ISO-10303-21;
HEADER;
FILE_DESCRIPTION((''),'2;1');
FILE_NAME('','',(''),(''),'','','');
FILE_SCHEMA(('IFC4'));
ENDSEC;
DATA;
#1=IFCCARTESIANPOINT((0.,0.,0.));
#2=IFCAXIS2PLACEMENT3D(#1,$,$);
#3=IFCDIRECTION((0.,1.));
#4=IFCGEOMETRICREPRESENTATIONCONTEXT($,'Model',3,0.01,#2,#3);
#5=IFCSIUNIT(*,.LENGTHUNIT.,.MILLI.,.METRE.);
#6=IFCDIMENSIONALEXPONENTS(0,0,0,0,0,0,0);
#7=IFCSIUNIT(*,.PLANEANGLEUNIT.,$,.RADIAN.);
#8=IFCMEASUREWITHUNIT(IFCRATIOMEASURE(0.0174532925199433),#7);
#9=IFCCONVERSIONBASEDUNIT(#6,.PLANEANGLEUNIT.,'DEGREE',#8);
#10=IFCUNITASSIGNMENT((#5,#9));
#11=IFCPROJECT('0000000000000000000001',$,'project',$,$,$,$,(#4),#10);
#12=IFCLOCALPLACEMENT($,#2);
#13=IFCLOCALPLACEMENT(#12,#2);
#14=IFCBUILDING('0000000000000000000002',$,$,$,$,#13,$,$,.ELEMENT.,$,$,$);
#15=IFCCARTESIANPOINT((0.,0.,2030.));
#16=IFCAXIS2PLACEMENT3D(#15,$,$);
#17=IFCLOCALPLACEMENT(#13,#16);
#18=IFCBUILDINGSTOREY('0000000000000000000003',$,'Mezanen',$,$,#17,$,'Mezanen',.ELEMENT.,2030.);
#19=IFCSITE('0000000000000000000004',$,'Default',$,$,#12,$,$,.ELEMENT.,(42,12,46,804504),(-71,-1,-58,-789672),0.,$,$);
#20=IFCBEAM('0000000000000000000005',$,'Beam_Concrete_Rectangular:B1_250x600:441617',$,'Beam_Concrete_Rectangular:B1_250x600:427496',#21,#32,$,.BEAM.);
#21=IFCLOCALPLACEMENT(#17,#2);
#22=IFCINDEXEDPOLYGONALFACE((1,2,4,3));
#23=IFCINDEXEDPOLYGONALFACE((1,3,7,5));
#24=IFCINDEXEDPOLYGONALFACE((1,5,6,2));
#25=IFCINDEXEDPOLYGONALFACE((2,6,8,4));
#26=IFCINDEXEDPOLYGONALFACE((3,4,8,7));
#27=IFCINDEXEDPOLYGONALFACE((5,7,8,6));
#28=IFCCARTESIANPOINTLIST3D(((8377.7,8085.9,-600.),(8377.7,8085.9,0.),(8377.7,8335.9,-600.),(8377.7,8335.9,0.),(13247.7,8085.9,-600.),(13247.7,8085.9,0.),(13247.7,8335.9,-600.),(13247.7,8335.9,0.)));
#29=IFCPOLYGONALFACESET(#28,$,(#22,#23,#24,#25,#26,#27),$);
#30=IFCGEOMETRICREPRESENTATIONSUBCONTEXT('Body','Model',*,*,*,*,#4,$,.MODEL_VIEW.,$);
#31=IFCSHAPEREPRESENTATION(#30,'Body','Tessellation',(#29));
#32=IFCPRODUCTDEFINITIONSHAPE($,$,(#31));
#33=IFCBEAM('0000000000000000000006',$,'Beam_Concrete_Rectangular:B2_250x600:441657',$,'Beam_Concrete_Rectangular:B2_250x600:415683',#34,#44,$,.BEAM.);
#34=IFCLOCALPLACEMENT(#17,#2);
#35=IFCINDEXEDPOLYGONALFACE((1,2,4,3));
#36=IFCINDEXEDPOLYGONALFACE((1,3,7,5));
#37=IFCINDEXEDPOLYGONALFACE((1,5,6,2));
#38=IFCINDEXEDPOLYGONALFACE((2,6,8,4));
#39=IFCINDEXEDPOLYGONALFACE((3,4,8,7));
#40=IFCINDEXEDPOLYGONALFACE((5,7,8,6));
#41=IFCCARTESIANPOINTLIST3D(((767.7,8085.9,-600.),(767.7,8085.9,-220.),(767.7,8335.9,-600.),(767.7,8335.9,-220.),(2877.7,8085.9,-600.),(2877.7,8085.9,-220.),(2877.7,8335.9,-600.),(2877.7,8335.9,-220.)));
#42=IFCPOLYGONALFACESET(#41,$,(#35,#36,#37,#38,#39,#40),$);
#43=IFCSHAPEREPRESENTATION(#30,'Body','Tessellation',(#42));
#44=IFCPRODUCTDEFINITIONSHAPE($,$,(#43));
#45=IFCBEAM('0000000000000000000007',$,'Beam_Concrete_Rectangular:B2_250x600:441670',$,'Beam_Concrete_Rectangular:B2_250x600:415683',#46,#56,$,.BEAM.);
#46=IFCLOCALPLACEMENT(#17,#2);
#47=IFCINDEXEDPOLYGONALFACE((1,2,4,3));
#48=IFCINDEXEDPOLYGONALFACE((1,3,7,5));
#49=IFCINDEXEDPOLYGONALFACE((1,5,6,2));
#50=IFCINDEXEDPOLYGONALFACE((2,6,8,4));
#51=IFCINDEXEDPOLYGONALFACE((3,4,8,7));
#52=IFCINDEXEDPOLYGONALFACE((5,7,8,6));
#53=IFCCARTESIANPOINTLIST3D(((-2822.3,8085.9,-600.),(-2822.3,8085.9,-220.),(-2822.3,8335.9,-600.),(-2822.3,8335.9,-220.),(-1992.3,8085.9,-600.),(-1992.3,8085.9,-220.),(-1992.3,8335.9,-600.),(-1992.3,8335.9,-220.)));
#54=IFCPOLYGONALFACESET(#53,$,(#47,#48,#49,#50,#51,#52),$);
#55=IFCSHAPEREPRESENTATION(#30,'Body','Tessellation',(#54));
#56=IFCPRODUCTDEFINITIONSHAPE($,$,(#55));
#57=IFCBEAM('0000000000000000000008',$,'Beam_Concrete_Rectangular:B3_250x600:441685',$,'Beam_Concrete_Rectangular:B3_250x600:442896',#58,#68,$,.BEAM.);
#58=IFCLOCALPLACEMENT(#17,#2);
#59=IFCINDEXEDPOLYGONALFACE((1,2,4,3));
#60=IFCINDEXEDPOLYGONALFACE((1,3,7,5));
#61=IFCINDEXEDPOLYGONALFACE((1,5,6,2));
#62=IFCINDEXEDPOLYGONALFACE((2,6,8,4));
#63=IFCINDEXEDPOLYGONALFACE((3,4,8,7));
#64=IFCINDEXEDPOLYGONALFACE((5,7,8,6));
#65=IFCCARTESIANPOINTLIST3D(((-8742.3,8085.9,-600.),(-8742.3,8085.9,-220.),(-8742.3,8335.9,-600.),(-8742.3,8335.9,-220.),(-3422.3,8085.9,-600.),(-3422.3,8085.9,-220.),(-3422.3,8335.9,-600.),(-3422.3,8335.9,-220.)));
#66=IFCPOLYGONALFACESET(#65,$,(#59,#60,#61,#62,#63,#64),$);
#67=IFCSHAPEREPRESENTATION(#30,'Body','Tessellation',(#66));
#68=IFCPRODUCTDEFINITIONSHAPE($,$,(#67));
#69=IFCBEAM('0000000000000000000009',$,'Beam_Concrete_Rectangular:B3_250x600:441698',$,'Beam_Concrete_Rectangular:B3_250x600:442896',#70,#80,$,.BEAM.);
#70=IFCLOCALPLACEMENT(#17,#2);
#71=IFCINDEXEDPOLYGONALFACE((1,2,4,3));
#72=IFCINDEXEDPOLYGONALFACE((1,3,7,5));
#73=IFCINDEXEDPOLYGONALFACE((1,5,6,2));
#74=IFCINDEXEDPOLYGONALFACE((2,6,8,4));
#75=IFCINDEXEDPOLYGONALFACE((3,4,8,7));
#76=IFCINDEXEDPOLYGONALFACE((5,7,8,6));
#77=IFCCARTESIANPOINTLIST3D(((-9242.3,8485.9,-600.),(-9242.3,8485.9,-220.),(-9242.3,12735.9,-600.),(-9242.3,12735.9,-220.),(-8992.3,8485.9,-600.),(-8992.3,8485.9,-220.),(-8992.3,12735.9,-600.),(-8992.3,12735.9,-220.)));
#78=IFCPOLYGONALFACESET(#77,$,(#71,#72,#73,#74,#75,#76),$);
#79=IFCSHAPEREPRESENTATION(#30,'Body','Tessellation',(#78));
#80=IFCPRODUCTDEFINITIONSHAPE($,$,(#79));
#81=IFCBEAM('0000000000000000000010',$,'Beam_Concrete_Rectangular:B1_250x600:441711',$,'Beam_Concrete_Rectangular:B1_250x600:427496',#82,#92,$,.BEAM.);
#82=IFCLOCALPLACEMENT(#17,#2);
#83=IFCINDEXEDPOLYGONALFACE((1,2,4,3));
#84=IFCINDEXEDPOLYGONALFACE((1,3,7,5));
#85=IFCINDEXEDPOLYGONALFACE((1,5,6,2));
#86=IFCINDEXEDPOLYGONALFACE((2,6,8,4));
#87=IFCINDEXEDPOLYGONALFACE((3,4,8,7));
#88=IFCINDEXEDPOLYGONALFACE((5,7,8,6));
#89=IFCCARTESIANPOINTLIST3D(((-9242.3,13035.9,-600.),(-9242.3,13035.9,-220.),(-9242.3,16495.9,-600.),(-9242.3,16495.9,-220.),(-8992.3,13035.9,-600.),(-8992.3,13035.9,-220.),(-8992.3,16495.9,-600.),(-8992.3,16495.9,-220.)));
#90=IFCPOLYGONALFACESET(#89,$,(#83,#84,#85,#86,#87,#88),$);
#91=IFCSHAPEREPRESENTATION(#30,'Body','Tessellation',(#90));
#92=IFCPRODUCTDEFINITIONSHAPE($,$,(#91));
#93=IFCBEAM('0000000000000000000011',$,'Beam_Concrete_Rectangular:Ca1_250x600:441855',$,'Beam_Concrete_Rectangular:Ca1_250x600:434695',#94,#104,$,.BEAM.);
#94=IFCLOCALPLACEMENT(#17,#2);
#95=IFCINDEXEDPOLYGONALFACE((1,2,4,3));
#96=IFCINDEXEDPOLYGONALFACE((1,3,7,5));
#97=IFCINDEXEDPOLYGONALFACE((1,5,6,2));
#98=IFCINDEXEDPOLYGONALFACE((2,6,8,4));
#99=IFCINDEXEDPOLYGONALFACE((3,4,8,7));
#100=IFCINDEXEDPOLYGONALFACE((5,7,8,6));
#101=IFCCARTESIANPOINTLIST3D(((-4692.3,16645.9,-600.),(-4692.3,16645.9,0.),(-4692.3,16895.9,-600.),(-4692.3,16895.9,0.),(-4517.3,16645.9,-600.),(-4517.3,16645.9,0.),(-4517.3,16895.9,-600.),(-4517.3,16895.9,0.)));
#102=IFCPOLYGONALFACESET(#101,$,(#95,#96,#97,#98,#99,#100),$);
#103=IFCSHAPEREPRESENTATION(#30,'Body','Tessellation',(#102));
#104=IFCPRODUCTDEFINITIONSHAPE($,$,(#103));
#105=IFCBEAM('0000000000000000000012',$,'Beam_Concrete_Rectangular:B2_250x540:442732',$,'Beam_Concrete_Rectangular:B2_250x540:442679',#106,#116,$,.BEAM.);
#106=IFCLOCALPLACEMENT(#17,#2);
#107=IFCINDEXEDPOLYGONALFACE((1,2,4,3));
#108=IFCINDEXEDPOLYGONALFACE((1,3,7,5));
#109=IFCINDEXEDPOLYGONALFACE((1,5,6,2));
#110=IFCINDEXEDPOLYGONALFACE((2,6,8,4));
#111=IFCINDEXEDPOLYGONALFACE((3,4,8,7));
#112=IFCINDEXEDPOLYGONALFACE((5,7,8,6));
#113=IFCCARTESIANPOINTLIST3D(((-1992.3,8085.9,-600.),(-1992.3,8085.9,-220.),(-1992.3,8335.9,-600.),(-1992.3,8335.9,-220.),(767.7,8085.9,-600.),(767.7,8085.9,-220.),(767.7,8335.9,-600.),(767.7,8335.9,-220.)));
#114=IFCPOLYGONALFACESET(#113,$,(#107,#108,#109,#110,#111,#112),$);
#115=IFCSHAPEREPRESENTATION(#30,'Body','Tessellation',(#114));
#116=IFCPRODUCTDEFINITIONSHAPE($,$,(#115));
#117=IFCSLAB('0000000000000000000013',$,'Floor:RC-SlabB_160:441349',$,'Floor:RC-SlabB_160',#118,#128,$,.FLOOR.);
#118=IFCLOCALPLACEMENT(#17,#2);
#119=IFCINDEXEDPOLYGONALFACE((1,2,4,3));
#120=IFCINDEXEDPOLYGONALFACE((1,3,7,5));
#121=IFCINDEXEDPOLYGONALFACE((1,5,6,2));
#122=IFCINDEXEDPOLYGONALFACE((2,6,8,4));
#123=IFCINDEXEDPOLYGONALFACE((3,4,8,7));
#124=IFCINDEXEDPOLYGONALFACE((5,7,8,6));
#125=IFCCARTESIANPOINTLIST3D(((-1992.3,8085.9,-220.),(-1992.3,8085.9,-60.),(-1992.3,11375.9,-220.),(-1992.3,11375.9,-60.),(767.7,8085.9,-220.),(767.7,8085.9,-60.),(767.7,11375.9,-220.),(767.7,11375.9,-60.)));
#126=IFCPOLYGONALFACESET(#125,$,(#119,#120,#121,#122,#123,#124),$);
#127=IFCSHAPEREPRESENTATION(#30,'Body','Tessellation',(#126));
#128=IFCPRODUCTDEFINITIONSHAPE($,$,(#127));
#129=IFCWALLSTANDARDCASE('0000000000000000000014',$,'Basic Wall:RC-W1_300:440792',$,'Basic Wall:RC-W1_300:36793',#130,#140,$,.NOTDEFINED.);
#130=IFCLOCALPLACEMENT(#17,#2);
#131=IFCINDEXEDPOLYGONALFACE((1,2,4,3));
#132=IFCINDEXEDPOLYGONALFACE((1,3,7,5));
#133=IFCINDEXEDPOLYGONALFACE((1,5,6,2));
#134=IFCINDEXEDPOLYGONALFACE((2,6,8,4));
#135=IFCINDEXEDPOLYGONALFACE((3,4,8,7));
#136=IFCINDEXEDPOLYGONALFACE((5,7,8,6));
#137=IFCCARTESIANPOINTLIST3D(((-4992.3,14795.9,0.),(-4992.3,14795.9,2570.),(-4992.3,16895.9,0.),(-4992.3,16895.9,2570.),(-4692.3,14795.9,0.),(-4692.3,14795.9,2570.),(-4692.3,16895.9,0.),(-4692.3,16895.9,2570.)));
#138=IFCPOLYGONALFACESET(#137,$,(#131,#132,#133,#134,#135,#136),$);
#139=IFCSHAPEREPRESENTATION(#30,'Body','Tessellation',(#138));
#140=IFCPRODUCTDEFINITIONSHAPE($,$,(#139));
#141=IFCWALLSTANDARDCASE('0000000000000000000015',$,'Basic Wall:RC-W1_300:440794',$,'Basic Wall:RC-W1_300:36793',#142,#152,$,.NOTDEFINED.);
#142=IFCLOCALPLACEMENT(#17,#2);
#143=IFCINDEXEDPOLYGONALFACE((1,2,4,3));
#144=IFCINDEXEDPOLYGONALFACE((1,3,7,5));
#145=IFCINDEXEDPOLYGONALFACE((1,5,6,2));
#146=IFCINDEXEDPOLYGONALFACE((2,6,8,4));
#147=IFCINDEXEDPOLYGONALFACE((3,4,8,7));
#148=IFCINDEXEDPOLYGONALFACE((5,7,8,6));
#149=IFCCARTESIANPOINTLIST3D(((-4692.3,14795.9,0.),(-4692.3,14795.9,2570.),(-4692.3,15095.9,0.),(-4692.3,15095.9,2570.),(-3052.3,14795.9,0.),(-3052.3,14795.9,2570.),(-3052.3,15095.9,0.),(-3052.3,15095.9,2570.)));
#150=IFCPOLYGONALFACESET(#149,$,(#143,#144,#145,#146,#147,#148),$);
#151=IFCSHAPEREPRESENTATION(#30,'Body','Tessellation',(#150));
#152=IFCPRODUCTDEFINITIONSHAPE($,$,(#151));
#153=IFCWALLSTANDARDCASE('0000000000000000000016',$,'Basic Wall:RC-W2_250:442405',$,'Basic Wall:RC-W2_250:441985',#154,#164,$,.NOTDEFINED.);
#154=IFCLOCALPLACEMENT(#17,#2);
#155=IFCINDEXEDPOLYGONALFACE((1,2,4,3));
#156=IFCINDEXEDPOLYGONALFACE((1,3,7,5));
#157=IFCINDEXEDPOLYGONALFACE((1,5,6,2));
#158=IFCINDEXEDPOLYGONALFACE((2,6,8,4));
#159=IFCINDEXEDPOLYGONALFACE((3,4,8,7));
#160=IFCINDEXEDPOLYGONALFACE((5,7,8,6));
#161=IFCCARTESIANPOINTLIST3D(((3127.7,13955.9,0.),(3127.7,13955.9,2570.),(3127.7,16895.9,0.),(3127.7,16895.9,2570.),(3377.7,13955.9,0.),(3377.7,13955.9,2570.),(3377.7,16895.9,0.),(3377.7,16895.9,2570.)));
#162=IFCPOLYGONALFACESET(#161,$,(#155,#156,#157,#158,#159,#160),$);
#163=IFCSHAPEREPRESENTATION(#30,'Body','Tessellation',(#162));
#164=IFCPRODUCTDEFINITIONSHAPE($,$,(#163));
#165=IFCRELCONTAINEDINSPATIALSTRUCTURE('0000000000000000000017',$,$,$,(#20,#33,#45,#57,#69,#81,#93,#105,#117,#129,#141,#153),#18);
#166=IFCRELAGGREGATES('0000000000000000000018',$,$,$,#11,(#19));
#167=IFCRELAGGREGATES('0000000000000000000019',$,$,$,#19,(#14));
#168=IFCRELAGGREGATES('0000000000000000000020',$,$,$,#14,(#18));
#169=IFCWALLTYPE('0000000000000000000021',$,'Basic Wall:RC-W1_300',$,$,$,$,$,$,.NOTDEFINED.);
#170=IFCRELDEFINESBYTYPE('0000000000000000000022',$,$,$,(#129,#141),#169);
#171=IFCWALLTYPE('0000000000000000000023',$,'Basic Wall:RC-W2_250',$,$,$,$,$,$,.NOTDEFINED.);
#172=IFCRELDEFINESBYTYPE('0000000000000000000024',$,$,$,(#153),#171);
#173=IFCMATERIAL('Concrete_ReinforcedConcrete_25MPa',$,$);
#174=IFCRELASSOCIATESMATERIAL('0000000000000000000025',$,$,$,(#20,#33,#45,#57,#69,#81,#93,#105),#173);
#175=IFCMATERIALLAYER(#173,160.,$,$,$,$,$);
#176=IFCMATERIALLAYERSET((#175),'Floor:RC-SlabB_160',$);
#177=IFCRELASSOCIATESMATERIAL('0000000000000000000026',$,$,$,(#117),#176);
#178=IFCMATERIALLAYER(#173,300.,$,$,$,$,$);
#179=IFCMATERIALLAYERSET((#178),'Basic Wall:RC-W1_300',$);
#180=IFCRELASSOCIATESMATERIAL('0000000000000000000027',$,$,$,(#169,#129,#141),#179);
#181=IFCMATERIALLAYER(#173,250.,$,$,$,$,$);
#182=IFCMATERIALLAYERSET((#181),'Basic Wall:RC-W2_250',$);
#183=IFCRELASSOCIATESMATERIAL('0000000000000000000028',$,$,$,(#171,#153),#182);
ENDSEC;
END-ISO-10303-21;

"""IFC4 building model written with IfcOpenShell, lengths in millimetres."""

from ifc_helpers import new_model, entity, si_unit, converted_unit, direction, frame, frame_2d, origin, place, context, subcontext, project, spatial, polyline, rectangle, extrude, clip, bounded_halfspace, material, layer, layer_set, layer_usage, type_object, element, save


model = new_model("IFC4")

# Units and contexts
model_context = context("Model", 3, precision=0.01, world=origin(), true_north=direction((0.0, 1.0)))
body_context = subcontext(model_context, "Body", "Model", "MODEL_VIEW")
ifc_project = project(units=[si_unit("LENGTHUNIT", "METRE", prefix="MILLI"), converted_unit("PLANEANGLEUNIT", "DEGREE", entity("IfcRatioMeasure", 0.0174532925199433), si_unit("PLANEANGLEUNIT", "RADIAN"), dimensions=[0, 0, 0, 0, 0, 0, 0])], contexts=[model_context])

# Site, building, storey
site_placement = place(None, origin())
site = spatial("IfcSite", under=ifc_project, at=site_placement, Name="Default", CompositionType="ELEMENT", RefLatitude=(42, 12, 46, 804504), RefLongitude=(-71, -1, -58, -789672), RefElevation=0.0)
building_placement = place(site_placement, origin())
building = spatial("IfcBuilding", under=site, at=building_placement, CompositionType="ELEMENT")
storey_placement = place(building_placement, frame((0.0, 0.0, 2030.0)))
storey = spatial("IfcBuildingStorey", under=building, at=storey_placement, Name="Mezanen", LongName="Mezanen", CompositionType="ELEMENT", Elevation=2030.0)

# Shared definitions
ifc_material = material(Name="Concrete_ReinforcedConcrete_25MPa")

# Beams
beam_1_placement = place(storey_placement, frame((8027.7, 8085.9, 0.0)))
element("IfcBeam", 1, at=beam_1_placement, inside=storey, material=ifc_material, Name="Beam_Concrete_Rectangular:B1_250x600:441617", ObjectType="Beam_Concrete_Rectangular:B1_250x600:427496", PredefinedType="BEAM", context=body_context, shape_type="SweptSolid", body=[
    extrude(rectangle(XDim=600.0, YDim=250.0, at=frame_2d((0.0, 0.0), x_axis=(1.0, 0.0))), frame((350.0, 125.0, -300.0), z_axis=(1.0, 0.0, 0.0), x_axis=(0.0, 0.0, -1.0)), (0.0, 0.0, 1.0), 4870.0),
])
beam_2_placement = place(storey_placement, frame((767.7, 8085.9, 0.0)))
element("IfcBeam", 2, at=beam_2_placement, inside=storey, material=ifc_material, Name="Beam_Concrete_Rectangular:B2_250x600:441657", ObjectType="Beam_Concrete_Rectangular:B2_250x600:415683", PredefinedType="BEAM", context=body_context, shape_type="SweptSolid", body=[
    extrude(rectangle(XDim=380.0, YDim=250.0, at=frame_2d((0.0, 0.0), x_axis=(1.0, 0.0))), frame((0.0, 125.0, -410.0), z_axis=(1.0, 0.0, 0.0), x_axis=(0.0, 0.0, -1.0)), (0.0, 0.0, 1.0), 2110.0),
])
beam_3_placement = place(storey_placement, frame((-3122.3, 8085.9, 0.0)))
element("IfcBeam", 3, at=beam_3_placement, inside=storey, material=ifc_material, Name="Beam_Concrete_Rectangular:B2_250x600:441670", ObjectType="Beam_Concrete_Rectangular:B2_250x600:415683", PredefinedType="BEAM", context=body_context, shape_type="SweptSolid", body=[
    extrude(rectangle(XDim=380.0, YDim=250.0, at=frame_2d((0.0, 0.0), x_axis=(1.0, 0.0))), frame((300.0, 125.0, -410.0), z_axis=(1.0, 0.0, 0.0), x_axis=(0.0, 0.0, -1.0)), (0.0, 0.0, 1.0), 830.0),
])
beam_4_placement = place(storey_placement, frame((-8992.3, 8085.9, 0.0)))
element("IfcBeam", 4, at=beam_4_placement, inside=storey, material=ifc_material, Name="Beam_Concrete_Rectangular:B3_250x600:441685", ObjectType="Beam_Concrete_Rectangular:B3_250x600:442896", PredefinedType="BEAM", context=body_context, shape_type="SweptSolid", body=[
    extrude(rectangle(XDim=380.0, YDim=250.0, at=frame_2d((0.0, 0.0), x_axis=(1.0, 0.0))), frame((250.0, 125.0, -410.0), z_axis=(1.0, 0.0, 0.0), x_axis=(0.0, 0.0, -1.0)), (0.0, 0.0, 1.0), 5320.0),
])
beam_5_placement = place(storey_placement, frame((-9242.3, 12885.9, 0.0), z_axis=(0.0, 0.0, 1.0), x_axis=(0.0, -1.0, 0.0)))
element("IfcBeam", 5, at=beam_5_placement, inside=storey, material=ifc_material, Name="Beam_Concrete_Rectangular:B3_250x600:441698", ObjectType="Beam_Concrete_Rectangular:B3_250x600:442896", PredefinedType="BEAM", context=body_context, shape_type="SweptSolid", body=[
    extrude(rectangle(XDim=380.0, YDim=250.0, at=frame_2d((0.0, 0.0), x_axis=(1.0, 0.0))), frame((150.0, 125.0, -410.0), z_axis=(1.0, 0.0, 0.0), x_axis=(0.0, 0.0, -1.0)), (0.0, 0.0, 1.0), 4250.0),
])
beam_6_placement = place(storey_placement, frame((-9242.3, 16695.9, 0.0), z_axis=(0.0, 0.0, 1.0), x_axis=(0.0, -1.0, 0.0)))
element("IfcBeam", 6, at=beam_6_placement, inside=storey, material=ifc_material, Name="Beam_Concrete_Rectangular:B1_250x600:441711", ObjectType="Beam_Concrete_Rectangular:B1_250x600:427496", PredefinedType="BEAM", context=body_context, shape_type="SweptSolid", body=[
    extrude(rectangle(XDim=380.0, YDim=250.0, at=frame_2d((0.0, 0.0), x_axis=(1.0, 0.0))), frame((200.0, 125.0, -410.0), z_axis=(1.0, 0.0, 0.0), x_axis=(0.0, 0.0, -1.0)), (0.0, 0.0, 1.0), 3460.0),
])
beam_7_placement = place(storey_placement, frame((-4842.3, 16645.9, 0.0)))
element("IfcBeam", 7, at=beam_7_placement, inside=storey, material=ifc_material, Name="Beam_Concrete_Rectangular:Ca1_250x600:441855", ObjectType="Beam_Concrete_Rectangular:Ca1_250x600:434695", PredefinedType="BEAM", context=body_context, shape_type="SweptSolid", body=[
    extrude(rectangle(XDim=600.0, YDim=250.0, at=frame_2d((0.0, 0.0), x_axis=(1.0, 0.0))), frame((150.0, 125.0, -300.0), z_axis=(1.0, 0.0, 0.0), x_axis=(0.0, 0.0, -1.0)), (0.0, 0.0, 1.0), 175.0),
])
beam_8_placement = place(storey_placement, frame((-1992.3, 8085.9, 0.0)))
element("IfcBeam", 8, at=beam_8_placement, inside=storey, material=ifc_material, Name="Beam_Concrete_Rectangular:B2_250x540:442732", ObjectType="Beam_Concrete_Rectangular:B2_250x540:442679", PredefinedType="BEAM", context=body_context, shape_type="SweptSolid", body=[
    extrude(rectangle(XDim=380.0, YDim=250.0, at=frame_2d((0.0, 0.0), x_axis=(1.0, 0.0))), frame((0.0, 125.0, -410.0), z_axis=(1.0, 0.0, 0.0), x_axis=(0.0, 0.0, -1.0)), (0.0, 0.0, 1.0), 2760.0),
])

# Slab
ifc_layer_1 = layer(ifc_material, 160.0)
ifc_layer_set_1 = layer_set([ifc_layer_1], Name="Floor:RC-SlabB_160")
ifc_layer_usage_1 = layer_usage(ifc_layer_set_1, "AXIS3", "POSITIVE", 0.0)
slab_1_placement = place(storey_placement, origin())
element("IfcSlab", 9, at=slab_1_placement, inside=storey, material=ifc_layer_usage_1, Name="Floor:RC-SlabB_160:441349", ObjectType="Floor:RC-SlabB_160", PredefinedType="FLOOR", context=body_context, shape_type="SweptSolid", body=[
    extrude(rectangle(XDim=3290.0, YDim=2760.0, at=frame_2d((0.0, 0.0), x_axis=(1.0, 0.0))), frame((-612.3, 9730.9, -60.0), z_axis=(0.0, 0.0, -1.0), x_axis=(0.0, 1.0, 0.0)), (0.0, 0.0, 1.0), 160.0),
])

# Walls
ifc_layer_2 = layer(ifc_material, 300.0)
ifc_layer_set_2 = layer_set([ifc_layer_2], Name="Basic Wall:RC-W1_300")
ifc_layer_usage_2 = layer_usage(ifc_layer_set_2, "AXIS2", "NEGATIVE", 150.0)
wall_type_1 = type_object("IfcWallType", Name="Basic Wall:RC-W1_300", PredefinedType="NOTDEFINED", material=ifc_layer_set_2)
wall_1_placement = place(storey_placement, frame((-4842.3, 16895.9, 0.0), z_axis=(0.0, 0.0, 1.0), x_axis=(0.0, -1.0, 0.0)))
element("IfcWallStandardCase", 10, at=wall_1_placement, inside=storey, type_object=wall_type_1, material=ifc_layer_usage_2, Name="Basic Wall:RC-W1_300:440792", ObjectType="Basic Wall:RC-W1_300:36793", PredefinedType="NOTDEFINED", context=body_context, shape_type="SweptSolid", body=[
    extrude(rectangle(XDim=2100.0, YDim=300.0, at=frame_2d((1050.0, 0.0), x_axis=(-1.0, 0.0))), origin(), (0.0, 0.0, 1.0), 2570.0),
])
ifc_layer_usage_3 = layer_usage(ifc_layer_set_2, "AXIS2", "NEGATIVE", 150.0)
wall_2_placement = place(storey_placement, frame((-4692.3, 14945.9, 0.0)))
element("IfcWallStandardCase", 11, at=wall_2_placement, inside=storey, type_object=wall_type_1, material=ifc_layer_usage_3, Name="Basic Wall:RC-W1_300:440794", ObjectType="Basic Wall:RC-W1_300:36793", PredefinedType="NOTDEFINED", context=body_context, shape_type="SweptSolid", body=[
    extrude(rectangle(XDim=1640.0, YDim=300.0, at=frame_2d((820.0, 0.0), x_axis=(-1.0, 0.0))), origin(), (0.0, 0.0, 1.0), 2570.0),
])
ifc_layer_3 = layer(ifc_material, 250.0)
ifc_layer_set_3 = layer_set([ifc_layer_3], Name="Basic Wall:RC-W2_250")
ifc_layer_usage_4 = layer_usage(ifc_layer_set_3, "AXIS2", "NEGATIVE", 125.0)
wall_type_2 = type_object("IfcWallType", Name="Basic Wall:RC-W2_250", PredefinedType="NOTDEFINED", material=ifc_layer_set_3)
wall_3_placement = place(storey_placement, frame((3252.7, 13955.9, 0.0), z_axis=(0.0, 0.0, 1.0), x_axis=(0.0, 1.0, 0.0)))
element("IfcWallStandardCase", 12, at=wall_3_placement, inside=storey, type_object=wall_type_2, material=ifc_layer_usage_4, Name="Basic Wall:RC-W2_250:442405", ObjectType="Basic Wall:RC-W2_250:441985", PredefinedType="NOTDEFINED", context=body_context, shape_type="Clipping", body=[
    clip(extrude(rectangle(XDim=2940.0, YDim=250.0, at=frame_2d((1470.0, 0.0), x_axis=(-1.0, 0.0))), origin(), (0.0, 0.0, 1.0), 2570.0), bounded_halfspace(frame((0.0, -125.0, 2570.0), z_axis=(0.0, 0.0, -1.0), x_axis=(0.0, -1.0, 0.0)), True, frame((0.0, -125.0, 2570.0)), polyline([(0.0, 0.0), (2940.0, 0.0), (2940.0, 250.0), (0.0, 250.0), (0.0, 0.0)]))),
])

save(model, "model.ifc")
